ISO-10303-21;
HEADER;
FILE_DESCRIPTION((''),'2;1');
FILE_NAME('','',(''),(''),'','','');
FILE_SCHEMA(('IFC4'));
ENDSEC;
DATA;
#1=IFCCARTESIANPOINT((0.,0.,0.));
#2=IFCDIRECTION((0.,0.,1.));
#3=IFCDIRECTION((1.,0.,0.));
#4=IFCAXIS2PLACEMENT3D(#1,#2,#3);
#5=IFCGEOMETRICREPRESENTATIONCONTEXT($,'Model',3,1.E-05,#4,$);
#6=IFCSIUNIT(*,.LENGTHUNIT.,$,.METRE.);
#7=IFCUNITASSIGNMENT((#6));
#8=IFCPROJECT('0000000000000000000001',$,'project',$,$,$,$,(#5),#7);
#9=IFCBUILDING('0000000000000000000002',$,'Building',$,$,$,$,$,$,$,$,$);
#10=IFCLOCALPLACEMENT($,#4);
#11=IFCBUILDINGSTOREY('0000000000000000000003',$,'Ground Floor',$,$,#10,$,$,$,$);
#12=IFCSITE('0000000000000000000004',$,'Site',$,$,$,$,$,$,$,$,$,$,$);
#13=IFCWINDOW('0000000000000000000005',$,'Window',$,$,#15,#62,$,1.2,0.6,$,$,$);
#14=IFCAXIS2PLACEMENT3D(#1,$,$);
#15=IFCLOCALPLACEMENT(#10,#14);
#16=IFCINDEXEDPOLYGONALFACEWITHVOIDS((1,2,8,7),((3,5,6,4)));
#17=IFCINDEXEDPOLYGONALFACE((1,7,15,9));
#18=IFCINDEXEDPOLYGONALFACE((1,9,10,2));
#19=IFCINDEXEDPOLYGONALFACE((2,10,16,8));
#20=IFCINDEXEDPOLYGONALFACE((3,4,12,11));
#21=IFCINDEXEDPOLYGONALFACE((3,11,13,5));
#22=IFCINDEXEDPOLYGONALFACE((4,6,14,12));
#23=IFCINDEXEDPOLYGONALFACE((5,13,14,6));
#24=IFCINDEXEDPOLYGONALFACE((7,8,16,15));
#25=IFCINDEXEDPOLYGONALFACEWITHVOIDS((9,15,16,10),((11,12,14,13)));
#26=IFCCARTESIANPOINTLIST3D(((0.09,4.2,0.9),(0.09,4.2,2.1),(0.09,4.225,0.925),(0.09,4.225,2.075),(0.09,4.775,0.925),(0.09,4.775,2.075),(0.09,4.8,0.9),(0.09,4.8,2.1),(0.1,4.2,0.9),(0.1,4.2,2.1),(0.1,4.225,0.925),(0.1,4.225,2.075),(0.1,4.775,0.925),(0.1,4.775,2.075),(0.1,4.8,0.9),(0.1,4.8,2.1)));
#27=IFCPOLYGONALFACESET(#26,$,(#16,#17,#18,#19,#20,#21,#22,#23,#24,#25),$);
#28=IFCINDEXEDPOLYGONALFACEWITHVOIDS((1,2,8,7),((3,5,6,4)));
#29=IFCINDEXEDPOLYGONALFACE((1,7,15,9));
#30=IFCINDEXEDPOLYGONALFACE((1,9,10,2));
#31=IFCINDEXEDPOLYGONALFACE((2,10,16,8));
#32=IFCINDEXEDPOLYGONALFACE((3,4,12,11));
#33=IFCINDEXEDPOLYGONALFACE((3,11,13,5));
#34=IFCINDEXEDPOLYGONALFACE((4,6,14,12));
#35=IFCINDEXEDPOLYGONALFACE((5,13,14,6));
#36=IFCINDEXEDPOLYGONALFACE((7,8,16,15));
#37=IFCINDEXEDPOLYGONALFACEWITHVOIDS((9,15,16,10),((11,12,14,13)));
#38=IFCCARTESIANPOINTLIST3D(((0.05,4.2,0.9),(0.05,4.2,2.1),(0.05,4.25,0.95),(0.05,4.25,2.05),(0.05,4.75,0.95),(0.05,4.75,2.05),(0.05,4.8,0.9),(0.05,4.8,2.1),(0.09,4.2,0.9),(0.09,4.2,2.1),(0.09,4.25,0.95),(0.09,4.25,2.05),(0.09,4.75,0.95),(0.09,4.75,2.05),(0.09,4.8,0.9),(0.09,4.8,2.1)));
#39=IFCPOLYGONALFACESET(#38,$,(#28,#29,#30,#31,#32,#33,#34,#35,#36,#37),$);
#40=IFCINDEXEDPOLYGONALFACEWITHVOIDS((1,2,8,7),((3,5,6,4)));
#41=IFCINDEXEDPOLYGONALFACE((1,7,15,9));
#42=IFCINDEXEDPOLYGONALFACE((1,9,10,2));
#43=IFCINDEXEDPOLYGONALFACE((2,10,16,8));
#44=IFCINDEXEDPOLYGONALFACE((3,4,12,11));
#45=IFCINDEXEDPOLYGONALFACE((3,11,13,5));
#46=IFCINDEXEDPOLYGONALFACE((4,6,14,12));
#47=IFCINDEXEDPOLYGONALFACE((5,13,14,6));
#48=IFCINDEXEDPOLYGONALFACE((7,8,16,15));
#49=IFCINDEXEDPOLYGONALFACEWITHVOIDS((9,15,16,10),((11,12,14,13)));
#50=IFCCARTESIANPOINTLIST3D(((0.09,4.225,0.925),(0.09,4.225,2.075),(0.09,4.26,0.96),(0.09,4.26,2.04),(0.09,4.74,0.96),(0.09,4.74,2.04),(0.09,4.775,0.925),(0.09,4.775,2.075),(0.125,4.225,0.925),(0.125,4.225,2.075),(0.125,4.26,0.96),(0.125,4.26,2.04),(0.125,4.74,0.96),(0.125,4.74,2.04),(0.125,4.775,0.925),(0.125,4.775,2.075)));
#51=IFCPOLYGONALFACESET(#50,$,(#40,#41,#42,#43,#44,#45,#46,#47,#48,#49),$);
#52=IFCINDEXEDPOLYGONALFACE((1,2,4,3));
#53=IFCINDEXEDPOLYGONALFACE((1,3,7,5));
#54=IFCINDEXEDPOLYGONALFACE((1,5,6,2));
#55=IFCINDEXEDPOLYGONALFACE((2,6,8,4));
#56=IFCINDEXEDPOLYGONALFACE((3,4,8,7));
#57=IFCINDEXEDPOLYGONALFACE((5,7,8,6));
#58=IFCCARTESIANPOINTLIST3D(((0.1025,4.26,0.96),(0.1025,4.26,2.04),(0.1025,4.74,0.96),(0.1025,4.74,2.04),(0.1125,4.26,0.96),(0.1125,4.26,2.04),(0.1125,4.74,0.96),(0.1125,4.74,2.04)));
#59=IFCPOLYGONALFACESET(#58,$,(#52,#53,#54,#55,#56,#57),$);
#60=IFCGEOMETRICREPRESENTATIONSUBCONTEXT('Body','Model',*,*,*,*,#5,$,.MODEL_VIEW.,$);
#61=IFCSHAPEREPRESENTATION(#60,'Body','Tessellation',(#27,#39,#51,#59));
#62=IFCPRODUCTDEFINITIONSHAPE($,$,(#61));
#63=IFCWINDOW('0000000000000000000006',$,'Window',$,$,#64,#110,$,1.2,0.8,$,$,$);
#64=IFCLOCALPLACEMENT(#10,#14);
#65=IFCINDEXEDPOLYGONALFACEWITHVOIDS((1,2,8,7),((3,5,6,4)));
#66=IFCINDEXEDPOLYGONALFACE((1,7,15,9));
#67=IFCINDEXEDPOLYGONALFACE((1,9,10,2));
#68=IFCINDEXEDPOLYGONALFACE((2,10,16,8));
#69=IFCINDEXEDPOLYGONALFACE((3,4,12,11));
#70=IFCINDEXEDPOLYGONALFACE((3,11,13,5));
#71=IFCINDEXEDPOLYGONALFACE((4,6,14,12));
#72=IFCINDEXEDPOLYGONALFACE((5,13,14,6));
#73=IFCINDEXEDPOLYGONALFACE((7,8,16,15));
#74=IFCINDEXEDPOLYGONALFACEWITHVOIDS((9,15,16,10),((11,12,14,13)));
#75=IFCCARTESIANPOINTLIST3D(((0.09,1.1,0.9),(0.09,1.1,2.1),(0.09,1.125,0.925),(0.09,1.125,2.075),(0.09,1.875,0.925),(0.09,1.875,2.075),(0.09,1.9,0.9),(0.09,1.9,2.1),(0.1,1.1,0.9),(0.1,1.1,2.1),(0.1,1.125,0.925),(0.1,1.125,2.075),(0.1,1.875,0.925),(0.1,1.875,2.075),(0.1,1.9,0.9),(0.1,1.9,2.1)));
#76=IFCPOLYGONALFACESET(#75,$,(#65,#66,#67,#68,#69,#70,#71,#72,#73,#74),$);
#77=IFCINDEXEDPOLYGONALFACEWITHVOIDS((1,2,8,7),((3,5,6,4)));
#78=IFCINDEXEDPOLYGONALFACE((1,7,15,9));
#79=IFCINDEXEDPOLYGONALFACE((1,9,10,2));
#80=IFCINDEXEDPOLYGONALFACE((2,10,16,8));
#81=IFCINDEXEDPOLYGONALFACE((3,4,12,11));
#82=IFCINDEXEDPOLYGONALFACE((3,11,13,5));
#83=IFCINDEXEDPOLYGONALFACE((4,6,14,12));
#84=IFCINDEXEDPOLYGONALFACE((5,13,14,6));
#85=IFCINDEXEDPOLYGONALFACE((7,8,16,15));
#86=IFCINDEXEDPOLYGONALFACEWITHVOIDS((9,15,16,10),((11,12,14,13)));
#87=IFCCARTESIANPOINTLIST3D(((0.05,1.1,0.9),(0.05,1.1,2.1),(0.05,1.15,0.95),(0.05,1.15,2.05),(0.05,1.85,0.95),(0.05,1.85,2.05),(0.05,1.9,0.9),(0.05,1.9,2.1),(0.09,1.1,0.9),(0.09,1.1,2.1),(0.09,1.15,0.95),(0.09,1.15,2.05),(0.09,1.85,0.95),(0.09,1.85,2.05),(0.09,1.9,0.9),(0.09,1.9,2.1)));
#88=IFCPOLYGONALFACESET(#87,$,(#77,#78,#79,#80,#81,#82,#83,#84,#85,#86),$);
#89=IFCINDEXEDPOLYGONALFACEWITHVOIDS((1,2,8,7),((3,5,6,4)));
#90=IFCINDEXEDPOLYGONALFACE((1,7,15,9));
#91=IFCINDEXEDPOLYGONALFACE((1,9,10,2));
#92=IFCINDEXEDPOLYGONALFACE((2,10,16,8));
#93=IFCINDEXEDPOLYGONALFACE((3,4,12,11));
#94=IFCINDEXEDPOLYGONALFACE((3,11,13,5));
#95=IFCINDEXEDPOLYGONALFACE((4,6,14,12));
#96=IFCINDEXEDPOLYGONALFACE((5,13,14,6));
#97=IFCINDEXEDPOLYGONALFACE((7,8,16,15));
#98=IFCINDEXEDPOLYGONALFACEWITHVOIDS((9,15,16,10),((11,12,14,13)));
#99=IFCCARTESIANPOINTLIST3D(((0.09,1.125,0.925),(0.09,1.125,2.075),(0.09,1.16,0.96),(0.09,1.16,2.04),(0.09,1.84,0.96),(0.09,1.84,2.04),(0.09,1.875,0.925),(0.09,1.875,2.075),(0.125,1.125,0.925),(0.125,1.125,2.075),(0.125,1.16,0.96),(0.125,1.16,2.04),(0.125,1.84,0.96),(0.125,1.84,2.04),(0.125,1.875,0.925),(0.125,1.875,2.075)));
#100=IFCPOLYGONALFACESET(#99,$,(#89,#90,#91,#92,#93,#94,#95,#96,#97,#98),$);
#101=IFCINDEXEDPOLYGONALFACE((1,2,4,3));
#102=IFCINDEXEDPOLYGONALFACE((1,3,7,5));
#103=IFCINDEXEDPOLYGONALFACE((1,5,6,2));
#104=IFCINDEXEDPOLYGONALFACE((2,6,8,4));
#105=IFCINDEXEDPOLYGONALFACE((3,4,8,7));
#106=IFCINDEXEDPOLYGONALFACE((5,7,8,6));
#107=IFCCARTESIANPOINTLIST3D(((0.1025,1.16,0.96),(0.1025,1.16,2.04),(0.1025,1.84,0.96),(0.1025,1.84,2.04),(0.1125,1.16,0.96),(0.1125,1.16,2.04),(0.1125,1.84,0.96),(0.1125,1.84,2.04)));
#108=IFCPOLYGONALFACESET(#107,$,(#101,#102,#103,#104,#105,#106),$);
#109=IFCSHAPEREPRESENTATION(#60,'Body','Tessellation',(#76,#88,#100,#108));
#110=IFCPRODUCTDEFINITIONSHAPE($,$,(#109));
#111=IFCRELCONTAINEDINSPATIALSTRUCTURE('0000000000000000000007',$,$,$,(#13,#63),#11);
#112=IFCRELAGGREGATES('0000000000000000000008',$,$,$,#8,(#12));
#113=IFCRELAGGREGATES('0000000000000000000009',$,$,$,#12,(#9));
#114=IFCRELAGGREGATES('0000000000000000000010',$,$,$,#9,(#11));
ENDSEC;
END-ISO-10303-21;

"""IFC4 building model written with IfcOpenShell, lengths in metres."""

from ifc_helpers import new_model, si_unit, frame, origin_with_axes, place, context, subcontext, project, spatial, line, indexed_curve, outline, extrude, element, save


model = new_model("IFC4")

# Units and contexts
model_context = context("Model", 3, precision=1e-05, world=origin_with_axes())
body_context = subcontext(model_context, "Body", "Model", "MODEL_VIEW")
ifc_project = project(units=[si_unit("LENGTHUNIT", "METRE")], contexts=[model_context])

# Site, building, storey
site = spatial("IfcSite", under=ifc_project, Name="Site")
building = spatial("IfcBuilding", under=site, Name="Building")
storey_placement = place(None, origin_with_axes())
storey = spatial("IfcBuildingStorey", under=building, at=storey_placement, Name="Ground Floor")

# Windows
window_1_placement = place(storey_placement, frame((0.0, 4.8, 0.9), z_axis=(0.0, 0.0, 1.0), x_axis=(0.0, -1.0, 0.0)))
element("IfcWindow", 1, at=window_1_placement, inside=storey, Name="Window", OverallHeight=1.2, OverallWidth=0.6, context=body_context, shape_type="SweptSolid", body=[
    extrude(outline(indexed_curve([(0.0, 0.0), (0.6, 0.0), (0.6, 1.2), (0.0, 1.2)], segments=[line(1, 2, 3, 4, 1)]), holes=[indexed_curve([(0.025, 0.025), (0.575, 0.025), (0.575, 1.175), (0.025, 1.175)], segments=[line(1, 2, 3, 4, 1)])]), frame((0.0, 0.09, 0.0), z_axis=(0.0, -1.0, 0.0), x_axis=(1.0, 0.0, 0.0)), (0.0, 0.0, -1.0), 0.01),
    extrude(outline(indexed_curve([(0.0, 0.0), (0.6, 0.0), (0.6, 1.2), (0.0, 1.2)], segments=[line(1, 2, 3, 4, 1)]), holes=[indexed_curve([(0.05, 0.05), (0.55, 0.05), (0.55, 1.15), (0.05, 1.15)], segments=[line(1, 2, 3, 4, 1)])]), frame((0.0, 0.05, 0.0), z_axis=(0.0, -1.0, 0.0), x_axis=(1.0, 0.0, 0.0)), (0.0, 0.0, -1.0), 0.04),
    extrude(outline(indexed_curve([(0.0, 0.0), (0.55, 0.0), (0.55, 1.15), (0.0, 1.15)], segments=[line(1, 2, 3, 4, 1)]), holes=[indexed_curve([(0.035, 0.035), (0.515, 0.035), (0.515, 1.115), (0.035, 1.115)], segments=[line(1, 2, 3, 4, 1)])]), frame((0.025, 0.09, 0.025), z_axis=(0.0, -1.0, 0.0), x_axis=(1.0, 0.0, 0.0)), (0.0, 0.0, -1.0), 0.035),
    extrude(outline(indexed_curve([(0.035, 0.035), (0.515, 0.035), (0.515, 1.115), (0.035, 1.115)], segments=[line(1, 2, 3, 4, 1)])), frame((0.025, 0.1025, 0.025), z_axis=(0.0, -1.0, 0.0), x_axis=(1.0, 0.0, 0.0)), (0.0, 0.0, -1.0), 0.01),
])
window_2_placement = place(storey_placement, frame((0.0, 1.9, 0.9), z_axis=(0.0, 0.0, 1.0), x_axis=(0.0, -1.0, 0.0)))
element("IfcWindow", 2, at=window_2_placement, inside=storey, Name="Window", OverallHeight=1.2, OverallWidth=0.8, context=body_context, shape_type="SweptSolid", body=[
    extrude(outline(indexed_curve([(0.0, 0.0), (0.8, 0.0), (0.8, 1.2), (0.0, 1.2)], segments=[line(1, 2, 3, 4, 1)]), holes=[indexed_curve([(0.025, 0.025), (0.775, 0.025), (0.775, 1.175), (0.025, 1.175)], segments=[line(1, 2, 3, 4, 1)])]), frame((0.0, 0.09, 0.0), z_axis=(0.0, -1.0, 0.0), x_axis=(1.0, 0.0, 0.0)), (0.0, 0.0, -1.0), 0.01),
    extrude(outline(indexed_curve([(0.0, 0.0), (0.8, 0.0), (0.8, 1.2), (0.0, 1.2)], segments=[line(1, 2, 3, 4, 1)]), holes=[indexed_curve([(0.05, 0.05), (0.75, 0.05), (0.75, 1.15), (0.05, 1.15)], segments=[line(1, 2, 3, 4, 1)])]), frame((0.0, 0.05, 0.0), z_axis=(0.0, -1.0, 0.0), x_axis=(1.0, 0.0, 0.0)), (0.0, 0.0, -1.0), 0.04),
    extrude(outline(indexed_curve([(0.0, 0.0), (0.75, 0.0), (0.75, 1.15), (0.0, 1.15)], segments=[line(1, 2, 3, 4, 1)]), holes=[indexed_curve([(0.035, 0.035), (0.715, 0.035), (0.715, 1.115), (0.035, 1.115)], segments=[line(1, 2, 3, 4, 1)])]), frame((0.025, 0.09, 0.025), z_axis=(0.0, -1.0, 0.0), x_axis=(1.0, 0.0, 0.0)), (0.0, 0.0, -1.0), 0.035),
    extrude(outline(indexed_curve([(0.035, 0.035), (0.715, 0.035), (0.715, 1.115), (0.035, 1.115)], segments=[line(1, 2, 3, 4, 1)])), frame((0.025, 0.1025, 0.025), z_axis=(0.0, -1.0, 0.0), x_axis=(1.0, 0.0, 0.0)), (0.0, 0.0, -1.0), 0.01),
])

save(model, "model.ifc")
